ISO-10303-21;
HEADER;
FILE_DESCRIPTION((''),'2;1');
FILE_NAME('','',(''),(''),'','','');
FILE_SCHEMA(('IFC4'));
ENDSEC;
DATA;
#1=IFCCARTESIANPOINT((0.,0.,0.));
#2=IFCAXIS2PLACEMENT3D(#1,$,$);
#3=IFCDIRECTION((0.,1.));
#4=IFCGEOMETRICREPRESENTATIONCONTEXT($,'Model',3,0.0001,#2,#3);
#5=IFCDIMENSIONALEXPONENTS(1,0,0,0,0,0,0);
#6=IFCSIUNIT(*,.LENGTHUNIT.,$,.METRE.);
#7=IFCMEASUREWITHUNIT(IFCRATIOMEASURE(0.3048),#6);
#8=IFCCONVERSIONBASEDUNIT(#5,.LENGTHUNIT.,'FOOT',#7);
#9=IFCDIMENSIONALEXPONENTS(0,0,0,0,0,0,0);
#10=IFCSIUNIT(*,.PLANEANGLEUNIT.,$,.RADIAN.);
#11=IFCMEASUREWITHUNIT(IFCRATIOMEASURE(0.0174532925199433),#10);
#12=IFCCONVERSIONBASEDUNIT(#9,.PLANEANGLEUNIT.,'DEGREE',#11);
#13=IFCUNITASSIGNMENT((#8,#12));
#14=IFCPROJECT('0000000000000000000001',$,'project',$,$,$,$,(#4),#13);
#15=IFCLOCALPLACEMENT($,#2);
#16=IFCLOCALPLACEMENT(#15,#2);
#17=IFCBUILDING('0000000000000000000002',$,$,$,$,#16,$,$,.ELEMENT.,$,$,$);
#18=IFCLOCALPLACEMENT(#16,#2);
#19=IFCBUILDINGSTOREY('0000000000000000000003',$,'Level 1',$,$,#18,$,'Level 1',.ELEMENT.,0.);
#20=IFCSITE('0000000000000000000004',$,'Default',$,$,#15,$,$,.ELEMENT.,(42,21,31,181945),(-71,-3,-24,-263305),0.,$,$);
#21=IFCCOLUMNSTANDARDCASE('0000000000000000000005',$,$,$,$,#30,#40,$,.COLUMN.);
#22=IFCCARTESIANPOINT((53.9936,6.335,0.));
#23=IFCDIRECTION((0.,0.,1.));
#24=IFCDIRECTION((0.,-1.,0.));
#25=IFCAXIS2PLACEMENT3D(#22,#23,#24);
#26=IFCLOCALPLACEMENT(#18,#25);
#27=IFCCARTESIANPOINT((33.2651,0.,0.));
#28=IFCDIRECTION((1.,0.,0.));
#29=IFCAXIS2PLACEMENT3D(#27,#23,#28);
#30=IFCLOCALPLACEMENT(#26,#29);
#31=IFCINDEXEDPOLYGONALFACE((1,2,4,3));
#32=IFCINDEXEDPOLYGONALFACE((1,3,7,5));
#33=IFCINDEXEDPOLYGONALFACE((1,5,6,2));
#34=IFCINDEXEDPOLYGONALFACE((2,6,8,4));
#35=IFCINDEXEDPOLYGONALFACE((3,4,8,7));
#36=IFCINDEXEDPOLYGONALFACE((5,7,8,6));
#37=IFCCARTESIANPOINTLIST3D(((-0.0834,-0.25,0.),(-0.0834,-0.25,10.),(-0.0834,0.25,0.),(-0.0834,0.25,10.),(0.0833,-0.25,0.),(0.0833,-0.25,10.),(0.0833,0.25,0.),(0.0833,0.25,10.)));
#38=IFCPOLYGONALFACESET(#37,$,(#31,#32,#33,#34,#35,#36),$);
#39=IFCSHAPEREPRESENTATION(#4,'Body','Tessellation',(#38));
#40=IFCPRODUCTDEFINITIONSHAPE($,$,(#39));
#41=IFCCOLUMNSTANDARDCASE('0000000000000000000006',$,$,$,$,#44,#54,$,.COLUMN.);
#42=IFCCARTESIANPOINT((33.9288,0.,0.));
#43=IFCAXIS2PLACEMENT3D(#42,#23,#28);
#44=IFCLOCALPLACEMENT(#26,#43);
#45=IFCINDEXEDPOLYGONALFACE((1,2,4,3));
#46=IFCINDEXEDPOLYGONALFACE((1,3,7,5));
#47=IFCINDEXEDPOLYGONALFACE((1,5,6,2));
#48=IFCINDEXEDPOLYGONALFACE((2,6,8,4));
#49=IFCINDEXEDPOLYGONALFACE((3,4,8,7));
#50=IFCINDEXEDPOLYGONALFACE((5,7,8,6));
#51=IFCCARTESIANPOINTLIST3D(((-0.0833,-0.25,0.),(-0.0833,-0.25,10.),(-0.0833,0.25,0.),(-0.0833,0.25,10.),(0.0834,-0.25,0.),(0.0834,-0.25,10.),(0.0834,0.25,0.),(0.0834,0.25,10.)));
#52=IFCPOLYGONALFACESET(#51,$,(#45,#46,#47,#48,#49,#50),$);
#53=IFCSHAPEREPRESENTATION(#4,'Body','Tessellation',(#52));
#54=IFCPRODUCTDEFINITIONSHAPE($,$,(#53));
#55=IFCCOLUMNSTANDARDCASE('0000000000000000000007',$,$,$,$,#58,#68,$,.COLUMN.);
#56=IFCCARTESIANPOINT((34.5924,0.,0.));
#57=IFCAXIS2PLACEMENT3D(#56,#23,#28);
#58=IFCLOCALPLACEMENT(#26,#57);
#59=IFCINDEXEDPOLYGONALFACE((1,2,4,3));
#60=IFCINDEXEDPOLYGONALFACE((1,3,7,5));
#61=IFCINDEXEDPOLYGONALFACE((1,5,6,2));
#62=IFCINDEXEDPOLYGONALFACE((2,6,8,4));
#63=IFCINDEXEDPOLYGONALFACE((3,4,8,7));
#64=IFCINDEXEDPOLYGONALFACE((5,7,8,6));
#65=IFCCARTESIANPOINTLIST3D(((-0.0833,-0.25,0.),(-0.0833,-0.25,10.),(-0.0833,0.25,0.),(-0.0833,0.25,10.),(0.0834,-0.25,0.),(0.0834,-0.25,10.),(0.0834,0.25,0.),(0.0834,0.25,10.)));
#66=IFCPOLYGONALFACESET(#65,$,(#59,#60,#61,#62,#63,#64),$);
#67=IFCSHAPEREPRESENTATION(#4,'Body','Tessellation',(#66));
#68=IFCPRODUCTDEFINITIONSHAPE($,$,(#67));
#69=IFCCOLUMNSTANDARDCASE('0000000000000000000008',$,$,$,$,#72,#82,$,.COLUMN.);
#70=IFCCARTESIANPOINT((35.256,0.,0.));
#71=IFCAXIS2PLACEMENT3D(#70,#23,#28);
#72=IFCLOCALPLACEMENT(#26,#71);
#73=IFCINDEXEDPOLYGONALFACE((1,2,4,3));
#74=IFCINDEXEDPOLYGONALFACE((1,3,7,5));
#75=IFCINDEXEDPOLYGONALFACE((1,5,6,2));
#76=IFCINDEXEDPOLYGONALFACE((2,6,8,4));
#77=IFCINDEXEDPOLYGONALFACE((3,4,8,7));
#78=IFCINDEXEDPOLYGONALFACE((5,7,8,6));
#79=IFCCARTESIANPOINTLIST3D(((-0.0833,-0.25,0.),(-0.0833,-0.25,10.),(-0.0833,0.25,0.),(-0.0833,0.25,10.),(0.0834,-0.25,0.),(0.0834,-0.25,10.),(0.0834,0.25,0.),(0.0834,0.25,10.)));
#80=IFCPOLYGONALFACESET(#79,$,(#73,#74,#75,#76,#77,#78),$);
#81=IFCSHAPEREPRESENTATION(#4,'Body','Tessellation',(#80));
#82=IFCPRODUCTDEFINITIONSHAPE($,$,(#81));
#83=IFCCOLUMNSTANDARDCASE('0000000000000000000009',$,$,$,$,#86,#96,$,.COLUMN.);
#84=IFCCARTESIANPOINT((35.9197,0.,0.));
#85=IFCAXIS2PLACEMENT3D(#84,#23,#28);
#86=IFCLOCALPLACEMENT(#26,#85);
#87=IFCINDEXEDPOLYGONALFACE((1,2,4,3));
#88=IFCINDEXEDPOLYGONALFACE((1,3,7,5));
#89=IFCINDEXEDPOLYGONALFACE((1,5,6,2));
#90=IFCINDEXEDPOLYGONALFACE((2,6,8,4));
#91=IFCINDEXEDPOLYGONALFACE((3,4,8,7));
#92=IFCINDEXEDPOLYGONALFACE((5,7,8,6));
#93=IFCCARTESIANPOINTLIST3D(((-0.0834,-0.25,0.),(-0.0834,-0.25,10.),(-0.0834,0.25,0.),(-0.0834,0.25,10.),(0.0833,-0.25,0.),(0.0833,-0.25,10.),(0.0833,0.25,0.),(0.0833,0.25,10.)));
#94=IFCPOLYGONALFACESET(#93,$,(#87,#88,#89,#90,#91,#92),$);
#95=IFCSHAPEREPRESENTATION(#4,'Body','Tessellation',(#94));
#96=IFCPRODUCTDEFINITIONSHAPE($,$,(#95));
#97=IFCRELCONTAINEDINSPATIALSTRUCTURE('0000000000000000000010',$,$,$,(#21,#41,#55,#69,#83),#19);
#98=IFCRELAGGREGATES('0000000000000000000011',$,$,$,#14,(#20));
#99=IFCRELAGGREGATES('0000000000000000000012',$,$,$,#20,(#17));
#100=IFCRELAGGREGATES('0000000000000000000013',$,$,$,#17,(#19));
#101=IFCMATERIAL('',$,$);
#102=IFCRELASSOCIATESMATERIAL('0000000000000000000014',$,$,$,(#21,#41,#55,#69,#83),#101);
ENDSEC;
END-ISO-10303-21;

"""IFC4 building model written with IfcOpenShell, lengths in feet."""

from ifc_helpers import new_model, entity, si_unit, converted_unit, direction, frame, origin, place, context, project, spatial, rectangle, extrude, material, element, save


model = new_model("IFC4")

# Units and contexts
model_context = context("Model", 3, precision=0.0001, world=origin(), true_north=direction((0.0, 1.0)))
ifc_project = project(units=[converted_unit("LENGTHUNIT", "FOOT", entity("IfcRatioMeasure", 0.3048), si_unit("LENGTHUNIT", "METRE"), dimensions=[1, 0, 0, 0, 0, 0, 0]), converted_unit("PLANEANGLEUNIT", "DEGREE", entity("IfcRatioMeasure", 0.0174532925199433), si_unit("PLANEANGLEUNIT", "RADIAN"), dimensions=[0, 0, 0, 0, 0, 0, 0])], contexts=[model_context])

# Site, building, storey
site_placement = place(None, origin())
site = spatial("IfcSite", under=ifc_project, at=site_placement, Name="Default", CompositionType="ELEMENT", RefLatitude=(42, 21, 31, 181945), RefLongitude=(-71, -3, -24, -263305), RefElevation=0.0)
building_placement = place(site_placement, origin())
building = spatial("IfcBuilding", under=site, at=building_placement, CompositionType="ELEMENT")
storey_placement = place(building_placement, origin())
storey = spatial("IfcBuildingStorey", under=building, at=storey_placement, Name="Level 1", LongName="Level 1", CompositionType="ELEMENT", Elevation=0.0)

# Columns
ifc_material_1 = material(Name="")
placement = place(storey_placement, frame((53.9936, 6.335, 0.0), z_axis=(0.0, 0.0, 1.0), x_axis=(0.0, -1.0, 0.0)))
for number, where, z_axis, x_axis in (
    (1, (33.2651, 0.0, 0.0), (0.0, 0.0, 1.0), (1.0, 0.0, 0.0)),
    (2, (33.9288, 0.0, 0.0), (0.0, 0.0, 1.0), (1.0, 0.0, 0.0)),
    (3, (34.5924, 0.0, 0.0), (0.0, 0.0, 1.0), (1.0, 0.0, 0.0)),
    (4, (35.256, 0.0, 0.0), (0.0, 0.0, 1.0), (1.0, 0.0, 0.0)),
    (5, (35.9197, 0.0, 0.0), (0.0, 0.0, 1.0), (1.0, 0.0, 0.0)),
):
    element("IfcColumnStandardCase", number, at=place(placement, frame(where, z_axis=z_axis, x_axis=x_axis)), inside=storey, material=ifc_material_1, PredefinedType="COLUMN", context=model_context, shape_type="SweptSolid", body=[
        extrude(rectangle(XDim=0.1667, YDim=0.5), origin(), (0.0, 0.0, 1.0), 10.0),
    ])

save(model, "model.ifc")
